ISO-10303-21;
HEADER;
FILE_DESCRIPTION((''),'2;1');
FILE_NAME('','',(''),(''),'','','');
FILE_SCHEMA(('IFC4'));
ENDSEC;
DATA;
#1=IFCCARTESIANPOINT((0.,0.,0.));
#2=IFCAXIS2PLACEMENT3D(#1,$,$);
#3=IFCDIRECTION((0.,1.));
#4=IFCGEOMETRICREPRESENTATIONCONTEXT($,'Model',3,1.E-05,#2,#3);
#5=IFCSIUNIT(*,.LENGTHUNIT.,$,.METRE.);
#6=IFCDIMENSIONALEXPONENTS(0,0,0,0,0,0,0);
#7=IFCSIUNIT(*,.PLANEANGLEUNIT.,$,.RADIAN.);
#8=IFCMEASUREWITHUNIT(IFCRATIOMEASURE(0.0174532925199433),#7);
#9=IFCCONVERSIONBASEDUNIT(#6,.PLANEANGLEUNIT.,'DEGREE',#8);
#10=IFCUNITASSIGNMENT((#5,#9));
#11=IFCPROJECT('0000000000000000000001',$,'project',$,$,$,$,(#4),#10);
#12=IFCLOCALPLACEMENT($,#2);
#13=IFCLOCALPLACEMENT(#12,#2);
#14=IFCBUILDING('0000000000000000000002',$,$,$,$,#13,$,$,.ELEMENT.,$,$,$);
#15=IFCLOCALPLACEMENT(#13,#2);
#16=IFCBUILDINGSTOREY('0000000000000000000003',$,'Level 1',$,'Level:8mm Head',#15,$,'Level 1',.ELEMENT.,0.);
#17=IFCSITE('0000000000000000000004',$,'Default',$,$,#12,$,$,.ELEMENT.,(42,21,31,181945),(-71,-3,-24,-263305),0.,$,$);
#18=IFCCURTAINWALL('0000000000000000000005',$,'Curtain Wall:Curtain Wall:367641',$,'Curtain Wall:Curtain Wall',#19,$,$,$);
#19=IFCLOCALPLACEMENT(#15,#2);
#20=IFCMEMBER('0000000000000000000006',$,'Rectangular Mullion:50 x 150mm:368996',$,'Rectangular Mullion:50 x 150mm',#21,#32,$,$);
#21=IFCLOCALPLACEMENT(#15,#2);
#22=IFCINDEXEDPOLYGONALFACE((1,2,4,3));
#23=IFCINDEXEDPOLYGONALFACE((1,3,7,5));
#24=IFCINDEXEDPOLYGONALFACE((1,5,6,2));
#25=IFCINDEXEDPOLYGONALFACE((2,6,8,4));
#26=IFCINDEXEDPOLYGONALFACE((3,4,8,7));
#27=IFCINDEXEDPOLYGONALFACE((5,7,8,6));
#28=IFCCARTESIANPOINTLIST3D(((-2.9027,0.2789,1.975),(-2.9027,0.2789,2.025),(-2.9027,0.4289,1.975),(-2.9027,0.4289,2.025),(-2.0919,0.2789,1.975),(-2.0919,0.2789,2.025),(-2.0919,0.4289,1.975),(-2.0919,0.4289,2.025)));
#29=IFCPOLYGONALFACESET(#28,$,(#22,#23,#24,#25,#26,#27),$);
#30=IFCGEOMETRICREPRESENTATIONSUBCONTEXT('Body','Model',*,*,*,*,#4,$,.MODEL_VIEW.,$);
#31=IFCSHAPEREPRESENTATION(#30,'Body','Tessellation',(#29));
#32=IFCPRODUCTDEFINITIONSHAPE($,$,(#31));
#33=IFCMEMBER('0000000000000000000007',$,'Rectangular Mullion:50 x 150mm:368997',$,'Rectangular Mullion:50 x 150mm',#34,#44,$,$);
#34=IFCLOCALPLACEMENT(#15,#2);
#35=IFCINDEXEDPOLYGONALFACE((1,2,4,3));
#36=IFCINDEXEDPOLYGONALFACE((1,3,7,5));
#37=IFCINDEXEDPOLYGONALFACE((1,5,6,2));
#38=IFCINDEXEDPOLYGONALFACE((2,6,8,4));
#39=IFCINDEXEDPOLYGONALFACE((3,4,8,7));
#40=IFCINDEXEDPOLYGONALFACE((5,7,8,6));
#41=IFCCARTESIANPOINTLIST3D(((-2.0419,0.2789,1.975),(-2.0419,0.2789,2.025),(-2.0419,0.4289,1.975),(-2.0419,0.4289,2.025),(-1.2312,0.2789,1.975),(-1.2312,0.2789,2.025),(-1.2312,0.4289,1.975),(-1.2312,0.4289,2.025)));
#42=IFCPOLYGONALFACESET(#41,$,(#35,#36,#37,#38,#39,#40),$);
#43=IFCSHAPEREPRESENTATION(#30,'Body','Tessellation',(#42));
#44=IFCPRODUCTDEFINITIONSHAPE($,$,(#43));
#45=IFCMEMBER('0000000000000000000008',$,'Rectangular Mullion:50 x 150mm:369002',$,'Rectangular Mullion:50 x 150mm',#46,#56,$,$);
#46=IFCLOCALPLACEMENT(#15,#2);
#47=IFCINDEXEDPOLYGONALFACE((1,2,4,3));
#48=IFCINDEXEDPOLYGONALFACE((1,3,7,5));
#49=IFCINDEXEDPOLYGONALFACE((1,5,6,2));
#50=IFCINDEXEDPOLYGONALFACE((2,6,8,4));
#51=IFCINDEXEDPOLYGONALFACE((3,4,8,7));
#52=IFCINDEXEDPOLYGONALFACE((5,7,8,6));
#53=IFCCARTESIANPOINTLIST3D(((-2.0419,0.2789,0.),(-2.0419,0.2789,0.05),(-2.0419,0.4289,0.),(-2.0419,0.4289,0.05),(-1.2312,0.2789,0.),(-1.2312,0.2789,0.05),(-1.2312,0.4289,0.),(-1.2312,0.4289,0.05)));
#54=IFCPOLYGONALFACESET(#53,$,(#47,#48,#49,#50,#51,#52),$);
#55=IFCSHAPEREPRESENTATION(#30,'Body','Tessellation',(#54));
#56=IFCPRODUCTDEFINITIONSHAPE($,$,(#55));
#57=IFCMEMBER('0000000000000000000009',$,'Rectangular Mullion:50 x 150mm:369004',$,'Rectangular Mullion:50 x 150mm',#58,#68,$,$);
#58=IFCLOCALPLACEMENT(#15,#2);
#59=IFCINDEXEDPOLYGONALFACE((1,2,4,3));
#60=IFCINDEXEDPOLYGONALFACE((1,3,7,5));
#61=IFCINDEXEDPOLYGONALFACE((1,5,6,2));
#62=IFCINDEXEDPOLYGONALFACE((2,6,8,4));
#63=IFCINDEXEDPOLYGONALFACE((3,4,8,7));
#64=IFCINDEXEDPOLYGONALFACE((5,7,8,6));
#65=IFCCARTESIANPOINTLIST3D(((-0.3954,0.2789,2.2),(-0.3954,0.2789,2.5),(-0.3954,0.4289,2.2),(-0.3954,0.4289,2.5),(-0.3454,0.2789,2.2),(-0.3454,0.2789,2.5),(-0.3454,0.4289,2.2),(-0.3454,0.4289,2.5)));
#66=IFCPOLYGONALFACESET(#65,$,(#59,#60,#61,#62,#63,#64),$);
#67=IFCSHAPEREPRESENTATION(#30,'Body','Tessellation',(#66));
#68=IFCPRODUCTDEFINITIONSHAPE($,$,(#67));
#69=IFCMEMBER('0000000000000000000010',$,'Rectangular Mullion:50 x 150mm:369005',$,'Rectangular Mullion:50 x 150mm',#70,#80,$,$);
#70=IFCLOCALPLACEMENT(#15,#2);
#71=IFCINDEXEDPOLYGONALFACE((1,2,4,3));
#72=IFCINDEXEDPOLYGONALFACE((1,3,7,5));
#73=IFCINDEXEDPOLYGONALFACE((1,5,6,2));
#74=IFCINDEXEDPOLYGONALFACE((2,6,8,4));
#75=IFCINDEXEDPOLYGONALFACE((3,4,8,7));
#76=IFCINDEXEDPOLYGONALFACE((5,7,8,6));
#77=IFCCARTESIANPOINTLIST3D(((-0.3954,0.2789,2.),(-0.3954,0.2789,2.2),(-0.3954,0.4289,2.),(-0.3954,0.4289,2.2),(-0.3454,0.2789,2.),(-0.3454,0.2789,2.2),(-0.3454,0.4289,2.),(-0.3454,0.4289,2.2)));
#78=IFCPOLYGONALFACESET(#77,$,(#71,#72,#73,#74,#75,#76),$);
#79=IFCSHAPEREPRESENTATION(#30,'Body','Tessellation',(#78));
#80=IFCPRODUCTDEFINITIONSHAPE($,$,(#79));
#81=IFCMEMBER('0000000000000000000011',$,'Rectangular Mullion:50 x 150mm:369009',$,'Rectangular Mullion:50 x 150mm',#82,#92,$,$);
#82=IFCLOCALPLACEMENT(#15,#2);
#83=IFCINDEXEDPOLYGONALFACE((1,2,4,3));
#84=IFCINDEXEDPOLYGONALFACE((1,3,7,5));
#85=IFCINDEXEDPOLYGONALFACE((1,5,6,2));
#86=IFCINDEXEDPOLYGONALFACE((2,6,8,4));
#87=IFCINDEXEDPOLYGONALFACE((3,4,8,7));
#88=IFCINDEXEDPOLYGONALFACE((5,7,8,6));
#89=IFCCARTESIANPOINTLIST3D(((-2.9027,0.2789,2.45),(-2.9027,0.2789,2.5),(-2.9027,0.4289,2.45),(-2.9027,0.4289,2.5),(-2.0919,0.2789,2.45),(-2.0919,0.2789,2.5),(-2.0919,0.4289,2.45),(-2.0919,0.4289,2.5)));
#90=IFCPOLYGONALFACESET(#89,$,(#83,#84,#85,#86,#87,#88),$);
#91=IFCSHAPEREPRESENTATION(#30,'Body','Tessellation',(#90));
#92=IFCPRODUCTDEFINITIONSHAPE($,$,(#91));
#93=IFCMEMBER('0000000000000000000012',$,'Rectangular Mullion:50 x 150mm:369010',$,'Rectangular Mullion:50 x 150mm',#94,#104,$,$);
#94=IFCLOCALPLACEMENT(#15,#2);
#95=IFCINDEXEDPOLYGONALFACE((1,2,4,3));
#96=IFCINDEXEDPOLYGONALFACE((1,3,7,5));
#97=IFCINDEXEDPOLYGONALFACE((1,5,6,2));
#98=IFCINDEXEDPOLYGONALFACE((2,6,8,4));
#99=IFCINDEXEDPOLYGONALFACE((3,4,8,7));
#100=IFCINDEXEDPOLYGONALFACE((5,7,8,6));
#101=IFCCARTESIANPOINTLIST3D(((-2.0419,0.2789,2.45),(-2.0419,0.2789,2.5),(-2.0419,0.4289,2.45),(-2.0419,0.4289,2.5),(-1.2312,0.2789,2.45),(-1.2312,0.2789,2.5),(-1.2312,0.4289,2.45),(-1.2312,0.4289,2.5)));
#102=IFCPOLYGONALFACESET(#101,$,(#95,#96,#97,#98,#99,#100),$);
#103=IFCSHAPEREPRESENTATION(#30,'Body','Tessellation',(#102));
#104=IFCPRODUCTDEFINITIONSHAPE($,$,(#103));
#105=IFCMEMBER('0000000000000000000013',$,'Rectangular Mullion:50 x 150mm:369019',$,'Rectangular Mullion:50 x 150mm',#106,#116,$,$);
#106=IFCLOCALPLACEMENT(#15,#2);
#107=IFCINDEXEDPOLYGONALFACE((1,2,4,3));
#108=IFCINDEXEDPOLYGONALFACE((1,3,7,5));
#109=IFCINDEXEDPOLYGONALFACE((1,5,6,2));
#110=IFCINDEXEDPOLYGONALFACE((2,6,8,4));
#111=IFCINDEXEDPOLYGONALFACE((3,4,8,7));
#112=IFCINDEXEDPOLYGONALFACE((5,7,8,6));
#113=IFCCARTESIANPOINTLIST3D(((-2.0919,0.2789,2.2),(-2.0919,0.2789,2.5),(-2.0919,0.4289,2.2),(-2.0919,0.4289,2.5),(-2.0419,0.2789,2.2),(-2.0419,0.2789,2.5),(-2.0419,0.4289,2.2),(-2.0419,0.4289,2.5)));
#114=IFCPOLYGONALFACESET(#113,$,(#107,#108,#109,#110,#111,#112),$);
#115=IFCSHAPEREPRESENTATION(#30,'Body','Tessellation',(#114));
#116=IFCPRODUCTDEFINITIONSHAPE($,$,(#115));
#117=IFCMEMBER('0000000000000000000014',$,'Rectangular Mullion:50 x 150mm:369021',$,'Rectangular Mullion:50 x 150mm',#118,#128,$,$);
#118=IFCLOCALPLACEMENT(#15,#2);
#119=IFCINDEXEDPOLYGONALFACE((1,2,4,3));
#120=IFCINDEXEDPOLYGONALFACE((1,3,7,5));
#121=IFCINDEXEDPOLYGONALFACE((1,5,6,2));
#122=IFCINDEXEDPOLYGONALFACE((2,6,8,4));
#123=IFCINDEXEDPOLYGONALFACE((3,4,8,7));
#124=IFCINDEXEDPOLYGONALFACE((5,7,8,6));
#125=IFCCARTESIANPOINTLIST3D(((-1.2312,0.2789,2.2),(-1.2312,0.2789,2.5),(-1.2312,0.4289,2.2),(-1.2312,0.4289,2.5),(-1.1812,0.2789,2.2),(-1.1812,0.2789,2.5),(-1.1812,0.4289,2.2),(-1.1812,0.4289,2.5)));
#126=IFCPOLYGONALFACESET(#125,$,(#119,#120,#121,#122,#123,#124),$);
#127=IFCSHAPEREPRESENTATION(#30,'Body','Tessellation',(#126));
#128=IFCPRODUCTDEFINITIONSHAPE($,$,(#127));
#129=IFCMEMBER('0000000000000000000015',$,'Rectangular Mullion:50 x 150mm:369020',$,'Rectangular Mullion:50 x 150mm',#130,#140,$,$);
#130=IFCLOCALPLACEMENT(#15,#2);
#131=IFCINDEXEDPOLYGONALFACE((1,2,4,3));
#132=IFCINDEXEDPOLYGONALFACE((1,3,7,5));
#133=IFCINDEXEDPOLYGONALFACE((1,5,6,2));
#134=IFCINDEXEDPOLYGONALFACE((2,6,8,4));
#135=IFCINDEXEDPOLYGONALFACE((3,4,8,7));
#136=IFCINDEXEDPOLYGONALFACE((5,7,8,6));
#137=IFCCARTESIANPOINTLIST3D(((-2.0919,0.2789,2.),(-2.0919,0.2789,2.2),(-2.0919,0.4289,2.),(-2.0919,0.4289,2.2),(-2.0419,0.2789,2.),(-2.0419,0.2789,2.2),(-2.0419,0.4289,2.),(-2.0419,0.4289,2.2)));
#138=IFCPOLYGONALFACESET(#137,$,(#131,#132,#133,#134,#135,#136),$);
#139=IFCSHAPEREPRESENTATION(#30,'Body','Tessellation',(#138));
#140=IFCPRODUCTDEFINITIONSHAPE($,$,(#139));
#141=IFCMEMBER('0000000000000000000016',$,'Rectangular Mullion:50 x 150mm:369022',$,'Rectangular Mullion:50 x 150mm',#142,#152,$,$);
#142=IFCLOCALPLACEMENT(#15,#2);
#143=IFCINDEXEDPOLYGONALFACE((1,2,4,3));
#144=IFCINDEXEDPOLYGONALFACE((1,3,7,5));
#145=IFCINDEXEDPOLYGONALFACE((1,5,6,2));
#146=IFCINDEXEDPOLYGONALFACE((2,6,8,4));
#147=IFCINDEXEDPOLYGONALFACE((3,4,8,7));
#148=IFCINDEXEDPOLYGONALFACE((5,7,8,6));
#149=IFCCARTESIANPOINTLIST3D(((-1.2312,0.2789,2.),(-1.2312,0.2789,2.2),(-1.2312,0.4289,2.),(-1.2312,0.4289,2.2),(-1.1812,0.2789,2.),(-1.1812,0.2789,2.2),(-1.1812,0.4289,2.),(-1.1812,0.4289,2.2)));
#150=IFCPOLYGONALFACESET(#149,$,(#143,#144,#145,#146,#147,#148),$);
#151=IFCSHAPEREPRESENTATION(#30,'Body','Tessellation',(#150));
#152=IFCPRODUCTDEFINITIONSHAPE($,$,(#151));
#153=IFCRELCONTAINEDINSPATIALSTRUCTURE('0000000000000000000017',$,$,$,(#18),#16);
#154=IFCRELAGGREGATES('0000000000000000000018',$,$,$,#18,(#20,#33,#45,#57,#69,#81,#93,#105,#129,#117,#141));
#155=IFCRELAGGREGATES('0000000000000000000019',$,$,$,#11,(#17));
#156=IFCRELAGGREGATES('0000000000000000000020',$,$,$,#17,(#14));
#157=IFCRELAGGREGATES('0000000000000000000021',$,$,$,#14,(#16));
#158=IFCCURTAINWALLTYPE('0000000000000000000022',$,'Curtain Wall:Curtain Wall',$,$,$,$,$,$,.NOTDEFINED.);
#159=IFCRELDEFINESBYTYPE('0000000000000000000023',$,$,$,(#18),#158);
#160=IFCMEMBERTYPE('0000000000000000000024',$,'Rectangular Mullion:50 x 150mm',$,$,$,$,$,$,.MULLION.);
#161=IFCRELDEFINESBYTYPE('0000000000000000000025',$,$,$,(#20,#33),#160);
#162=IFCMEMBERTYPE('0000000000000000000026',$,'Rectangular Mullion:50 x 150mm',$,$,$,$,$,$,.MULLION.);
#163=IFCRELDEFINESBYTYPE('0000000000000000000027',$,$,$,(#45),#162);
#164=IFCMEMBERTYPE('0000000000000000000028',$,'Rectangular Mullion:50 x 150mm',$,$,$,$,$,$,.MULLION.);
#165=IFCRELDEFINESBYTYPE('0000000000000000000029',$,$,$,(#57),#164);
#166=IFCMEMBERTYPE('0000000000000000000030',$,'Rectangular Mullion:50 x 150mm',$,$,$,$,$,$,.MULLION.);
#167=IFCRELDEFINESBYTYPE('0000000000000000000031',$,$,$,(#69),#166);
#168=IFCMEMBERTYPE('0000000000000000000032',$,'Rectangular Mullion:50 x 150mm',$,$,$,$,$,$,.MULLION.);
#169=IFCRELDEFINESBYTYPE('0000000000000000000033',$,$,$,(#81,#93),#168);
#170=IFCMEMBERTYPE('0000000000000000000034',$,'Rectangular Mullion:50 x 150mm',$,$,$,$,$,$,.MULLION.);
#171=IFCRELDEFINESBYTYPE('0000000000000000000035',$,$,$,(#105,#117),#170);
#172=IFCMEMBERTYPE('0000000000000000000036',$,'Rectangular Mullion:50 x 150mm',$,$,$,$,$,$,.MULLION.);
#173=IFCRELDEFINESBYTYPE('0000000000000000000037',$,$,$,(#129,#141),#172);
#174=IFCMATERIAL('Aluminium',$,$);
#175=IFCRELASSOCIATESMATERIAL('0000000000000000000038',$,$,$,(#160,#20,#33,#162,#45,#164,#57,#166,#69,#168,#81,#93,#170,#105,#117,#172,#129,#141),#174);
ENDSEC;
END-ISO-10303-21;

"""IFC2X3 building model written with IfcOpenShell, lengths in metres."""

from ifc_helpers import new_model, entity, si_unit, converted_unit, direction, frame, origin, origin_2d_with_axis, place, context, subcontext, project, spatial, rectangle, extrude, source, transform, mapped, material, type_object, type_shapes, element, aggregate, save


model = new_model("IFC2X3")

# Units and contexts
model_context = context("Model", 3, precision=1e-05, world=origin(), true_north=direction((0.0, 1.0)))
body_context = subcontext(model_context, "Body", "Model", "MODEL_VIEW")
ifc_project = project(units=[si_unit("LENGTHUNIT", "METRE"), converted_unit("PLANEANGLEUNIT", "DEGREE", entity("IfcRatioMeasure", 0.0174532925199433), si_unit("PLANEANGLEUNIT", "RADIAN"), dimensions=[0, 0, 0, 0, 0, 0, 0])], contexts=[model_context])

# Site, building, storey
site_placement = place(None, origin())
site = spatial("IfcSite", under=ifc_project, at=site_placement, Name="Default", CompositionType="ELEMENT", RefLatitude=(42, 21, 31, 181945), RefLongitude=(-71, -3, -24, -263305), RefElevation=0.0)
building_placement = place(site_placement, origin())
building = spatial("IfcBuilding", under=site, at=building_placement, CompositionType="ELEMENT")
storey_placement = place(building_placement, origin())
storey = spatial("IfcBuildingStorey", under=building, at=storey_placement, Name="Level 1", ObjectType="Level:8mm Head", LongName="Level 1", CompositionType="ELEMENT", Elevation=0.0)

# Curtain wall, members
curtain_wall_type = type_object("IfcCurtainWallType", Name="Curtain Wall:Curtain Wall", PredefinedType="NOTDEFINED")
curtain_wall_placement = place(storey_placement, origin())
curtain_wall = element("IfcCurtainWall", 1, at=curtain_wall_placement, inside=storey, type_object=curtain_wall_type, Name="Curtain Wall:Curtain Wall:367641", ObjectType="Curtain Wall:Curtain Wall")
ifc_material_1 = material(Name="Aluminium")
member_type_1 = type_object("IfcMemberType", Name="Rectangular Mullion:50 x 150mm", PredefinedType="MULLION", material=ifc_material_1)
shared_shape_1 = source(origin(), body_context, "Body", "SweptSolid", [
    extrude(rectangle(XDim=0.15, YDim=0.05, at=origin_2d_with_axis()), frame((0.0, 0.0, -0.8107), z_axis=(0.0, 0.0, 1.0), x_axis=(0.0, -1.0, 0.0)), (0.0, 0.0, 1.0), 0.8107),
])
type_shapes(member_type_1, [shared_shape_1])
member_1_placement = place(storey_placement, frame((-2.0919, 0.3539, 2.0), z_axis=(1.0, 0.0, 0.0), x_axis=(0.0, 0.0, 1.0)))
member_1 = element("IfcMember", 2, at=member_1_placement, type_object=member_type_1, material=ifc_material_1, Name="Rectangular Mullion:50 x 150mm:368996", ObjectType="Rectangular Mullion:50 x 150mm", context=body_context, shape_type="MappedRepresentation", body=[
    mapped(shared_shape_1, transform((0.0, 0.0, 0.0), scale=1.0)),
])
member_2_placement = place(storey_placement, frame((-1.2312, 0.3539, 2.0), z_axis=(1.0, 0.0, 0.0), x_axis=(0.0, 0.0, 1.0)))
member_2 = element("IfcMember", 3, at=member_2_placement, type_object=member_type_1, material=ifc_material_1, Name="Rectangular Mullion:50 x 150mm:368997", ObjectType="Rectangular Mullion:50 x 150mm", context=body_context, shape_type="MappedRepresentation", body=[
    mapped(shared_shape_1, transform((0.0, 0.0, 0.0), scale=1.0)),
])
member_type_2 = type_object("IfcMemberType", Name="Rectangular Mullion:50 x 150mm", PredefinedType="MULLION", material=ifc_material_1)
shared_shape_2 = source(origin(), body_context, "Body", "SweptSolid", [
    extrude(rectangle(XDim=0.15, YDim=0.05, at=origin_2d_with_axis()), frame((-0.025, 0.0, -0.8107), z_axis=(0.0, 0.0, 1.0), x_axis=(0.0, -1.0, 0.0)), (0.0, 0.0, 1.0), 0.8107),
])
type_shapes(member_type_2, [shared_shape_2])
member_3_placement = place(storey_placement, frame((-2.0419, 0.3539, 0.0), z_axis=(-1.0, 0.0, 0.0), x_axis=(0.0, 0.0, -1.0)))
member_3 = element("IfcMember", 4, at=member_3_placement, type_object=member_type_2, material=ifc_material_1, Name="Rectangular Mullion:50 x 150mm:369002", ObjectType="Rectangular Mullion:50 x 150mm", context=body_context, shape_type="MappedRepresentation", body=[
    mapped(shared_shape_2, transform((0.0, 0.0, 0.0), scale=1.0)),
])
member_type_3 = type_object("IfcMemberType", Name="Rectangular Mullion:50 x 150mm", PredefinedType="MULLION", material=ifc_material_1)
shared_shape_3 = source(origin(), body_context, "Body", "SweptSolid", [
    extrude(rectangle(XDim=0.15, YDim=0.05, at=origin_2d_with_axis()), frame((-0.025, 0.0, -0.3), z_axis=(0.0, 0.0, 1.0), x_axis=(0.0, -1.0, 0.0)), (0.0, 0.0, 1.0), 0.3),
])
type_shapes(member_type_3, [shared_shape_3])
member_4_placement = place(storey_placement, frame((-0.3454, 0.3539, 2.2), z_axis=(0.0, 0.0, -1.0), x_axis=(1.0, 0.0, 0.0)))
member_4 = element("IfcMember", 5, at=member_4_placement, type_object=member_type_3, material=ifc_material_1, Name="Rectangular Mullion:50 x 150mm:369004", ObjectType="Rectangular Mullion:50 x 150mm", context=body_context, shape_type="MappedRepresentation", body=[
    mapped(shared_shape_3, transform((0.0, 0.0, 0.0), scale=1.0)),
])
member_type_4 = type_object("IfcMemberType", Name="Rectangular Mullion:50 x 150mm", PredefinedType="MULLION", material=ifc_material_1)
shared_shape_4 = source(origin(), body_context, "Body", "SweptSolid", [
    extrude(rectangle(XDim=0.15, YDim=0.05, at=origin_2d_with_axis()), frame((-0.025, 0.0, -0.2), z_axis=(0.0, 0.0, 1.0), x_axis=(0.0, -1.0, 0.0)), (0.0, 0.0, 1.0), 0.2),
])
type_shapes(member_type_4, [shared_shape_4])
member_5_placement = place(storey_placement, frame((-0.3454, 0.3539, 2.0), z_axis=(0.0, 0.0, -1.0), x_axis=(1.0, 0.0, 0.0)))
member_5 = element("IfcMember", 6, at=member_5_placement, type_object=member_type_4, material=ifc_material_1, Name="Rectangular Mullion:50 x 150mm:369005", ObjectType="Rectangular Mullion:50 x 150mm", context=body_context, shape_type="MappedRepresentation", body=[
    mapped(shared_shape_4, transform((0.0, 0.0, 0.0), scale=1.0)),
])
member_type_5 = type_object("IfcMemberType", Name="Rectangular Mullion:50 x 150mm", PredefinedType="MULLION", material=ifc_material_1)
shared_shape_5 = source(origin(), body_context, "Body", "SweptSolid", [
    extrude(rectangle(XDim=0.15, YDim=0.05, at=origin_2d_with_axis()), frame((-0.025, 0.0, -0.8107), z_axis=(0.0, 0.0, 1.0), x_axis=(0.0, -1.0, 0.0)), (0.0, 0.0, 1.0), 0.8107),
])
type_shapes(member_type_5, [shared_shape_5])
member_6_placement = place(storey_placement, frame((-2.0919, 0.3539, 2.5), z_axis=(1.0, 0.0, 0.0), x_axis=(0.0, 0.0, 1.0)))
member_6 = element("IfcMember", 7, at=member_6_placement, type_object=member_type_5, material=ifc_material_1, Name="Rectangular Mullion:50 x 150mm:369009", ObjectType="Rectangular Mullion:50 x 150mm", context=body_context, shape_type="MappedRepresentation", body=[
    mapped(shared_shape_5, transform((0.0, 0.0, 0.0), scale=1.0)),
])
member_7_placement = place(storey_placement, frame((-1.2312, 0.3539, 2.5), z_axis=(1.0, 0.0, 0.0), x_axis=(0.0, 0.0, 1.0)))
member_7 = element("IfcMember", 8, at=member_7_placement, type_object=member_type_5, material=ifc_material_1, Name="Rectangular Mullion:50 x 150mm:369010", ObjectType="Rectangular Mullion:50 x 150mm", context=body_context, shape_type="MappedRepresentation", body=[
    mapped(shared_shape_5, transform((0.0, 0.0, 0.0), scale=1.0)),
])
member_type_6 = type_object("IfcMemberType", Name="Rectangular Mullion:50 x 150mm", PredefinedType="MULLION", material=ifc_material_1)
shared_shape_6 = source(origin(), body_context, "Body", "SweptSolid", [
    extrude(rectangle(XDim=0.15, YDim=0.05, at=origin_2d_with_axis()), frame((0.0, 0.0, -0.3), z_axis=(0.0, 0.0, 1.0), x_axis=(0.0, -1.0, 0.0)), (0.0, 0.0, 1.0), 0.3),
])
type_shapes(member_type_6, [shared_shape_6])
member_8_placement = place(storey_placement, frame((-2.0669, 0.3539, 2.2), z_axis=(0.0, 0.0, -1.0), x_axis=(1.0, 0.0, 0.0)))
member_8 = element("IfcMember", 9, at=member_8_placement, type_object=member_type_6, material=ifc_material_1, Name="Rectangular Mullion:50 x 150mm:369019", ObjectType="Rectangular Mullion:50 x 150mm", context=body_context, shape_type="MappedRepresentation", body=[
    mapped(shared_shape_6, transform((0.0, 0.0, 0.0), scale=1.0)),
])
member_9_placement = place(storey_placement, frame((-1.2062, 0.3539, 2.2), z_axis=(0.0, 0.0, -1.0), x_axis=(1.0, 0.0, 0.0)))
member_9 = element("IfcMember", 10, at=member_9_placement, type_object=member_type_6, material=ifc_material_1, Name="Rectangular Mullion:50 x 150mm:369021", ObjectType="Rectangular Mullion:50 x 150mm", context=body_context, shape_type="MappedRepresentation", body=[
    mapped(shared_shape_6, transform((0.0, 0.0, 0.0), scale=1.0)),
])
member_type_7 = type_object("IfcMemberType", Name="Rectangular Mullion:50 x 150mm", PredefinedType="MULLION", material=ifc_material_1)
shared_shape_7 = source(origin(), body_context, "Body", "SweptSolid", [
    extrude(rectangle(XDim=0.15, YDim=0.05, at=origin_2d_with_axis()), frame((0.0, 0.0, -0.2), z_axis=(0.0, 0.0, 1.0), x_axis=(0.0, -1.0, 0.0)), (0.0, 0.0, 1.0), 0.2),
])
type_shapes(member_type_7, [shared_shape_7])
member_10_placement = place(storey_placement, frame((-2.0669, 0.3539, 2.0), z_axis=(0.0, 0.0, -1.0), x_axis=(1.0, 0.0, 0.0)))
member_10 = element("IfcMember", 11, at=member_10_placement, type_object=member_type_7, material=ifc_material_1, Name="Rectangular Mullion:50 x 150mm:369020", ObjectType="Rectangular Mullion:50 x 150mm", context=body_context, shape_type="MappedRepresentation", body=[
    mapped(shared_shape_7, transform((0.0, 0.0, 0.0), scale=1.0)),
])
member_11_placement = place(storey_placement, frame((-1.2062, 0.3539, 2.0), z_axis=(0.0, 0.0, -1.0), x_axis=(1.0, 0.0, 0.0)))
member_11 = element("IfcMember", 12, at=member_11_placement, type_object=member_type_7, material=ifc_material_1, Name="Rectangular Mullion:50 x 150mm:369022", ObjectType="Rectangular Mullion:50 x 150mm", context=body_context, shape_type="MappedRepresentation", body=[
    mapped(shared_shape_7, transform((0.0, 0.0, 0.0), scale=1.0)),
])

aggregate(curtain_wall, [member_1, member_2, member_3, member_4, member_5, member_6, member_7, member_8, member_10, member_9, member_11])

save(model, "model.ifc")
